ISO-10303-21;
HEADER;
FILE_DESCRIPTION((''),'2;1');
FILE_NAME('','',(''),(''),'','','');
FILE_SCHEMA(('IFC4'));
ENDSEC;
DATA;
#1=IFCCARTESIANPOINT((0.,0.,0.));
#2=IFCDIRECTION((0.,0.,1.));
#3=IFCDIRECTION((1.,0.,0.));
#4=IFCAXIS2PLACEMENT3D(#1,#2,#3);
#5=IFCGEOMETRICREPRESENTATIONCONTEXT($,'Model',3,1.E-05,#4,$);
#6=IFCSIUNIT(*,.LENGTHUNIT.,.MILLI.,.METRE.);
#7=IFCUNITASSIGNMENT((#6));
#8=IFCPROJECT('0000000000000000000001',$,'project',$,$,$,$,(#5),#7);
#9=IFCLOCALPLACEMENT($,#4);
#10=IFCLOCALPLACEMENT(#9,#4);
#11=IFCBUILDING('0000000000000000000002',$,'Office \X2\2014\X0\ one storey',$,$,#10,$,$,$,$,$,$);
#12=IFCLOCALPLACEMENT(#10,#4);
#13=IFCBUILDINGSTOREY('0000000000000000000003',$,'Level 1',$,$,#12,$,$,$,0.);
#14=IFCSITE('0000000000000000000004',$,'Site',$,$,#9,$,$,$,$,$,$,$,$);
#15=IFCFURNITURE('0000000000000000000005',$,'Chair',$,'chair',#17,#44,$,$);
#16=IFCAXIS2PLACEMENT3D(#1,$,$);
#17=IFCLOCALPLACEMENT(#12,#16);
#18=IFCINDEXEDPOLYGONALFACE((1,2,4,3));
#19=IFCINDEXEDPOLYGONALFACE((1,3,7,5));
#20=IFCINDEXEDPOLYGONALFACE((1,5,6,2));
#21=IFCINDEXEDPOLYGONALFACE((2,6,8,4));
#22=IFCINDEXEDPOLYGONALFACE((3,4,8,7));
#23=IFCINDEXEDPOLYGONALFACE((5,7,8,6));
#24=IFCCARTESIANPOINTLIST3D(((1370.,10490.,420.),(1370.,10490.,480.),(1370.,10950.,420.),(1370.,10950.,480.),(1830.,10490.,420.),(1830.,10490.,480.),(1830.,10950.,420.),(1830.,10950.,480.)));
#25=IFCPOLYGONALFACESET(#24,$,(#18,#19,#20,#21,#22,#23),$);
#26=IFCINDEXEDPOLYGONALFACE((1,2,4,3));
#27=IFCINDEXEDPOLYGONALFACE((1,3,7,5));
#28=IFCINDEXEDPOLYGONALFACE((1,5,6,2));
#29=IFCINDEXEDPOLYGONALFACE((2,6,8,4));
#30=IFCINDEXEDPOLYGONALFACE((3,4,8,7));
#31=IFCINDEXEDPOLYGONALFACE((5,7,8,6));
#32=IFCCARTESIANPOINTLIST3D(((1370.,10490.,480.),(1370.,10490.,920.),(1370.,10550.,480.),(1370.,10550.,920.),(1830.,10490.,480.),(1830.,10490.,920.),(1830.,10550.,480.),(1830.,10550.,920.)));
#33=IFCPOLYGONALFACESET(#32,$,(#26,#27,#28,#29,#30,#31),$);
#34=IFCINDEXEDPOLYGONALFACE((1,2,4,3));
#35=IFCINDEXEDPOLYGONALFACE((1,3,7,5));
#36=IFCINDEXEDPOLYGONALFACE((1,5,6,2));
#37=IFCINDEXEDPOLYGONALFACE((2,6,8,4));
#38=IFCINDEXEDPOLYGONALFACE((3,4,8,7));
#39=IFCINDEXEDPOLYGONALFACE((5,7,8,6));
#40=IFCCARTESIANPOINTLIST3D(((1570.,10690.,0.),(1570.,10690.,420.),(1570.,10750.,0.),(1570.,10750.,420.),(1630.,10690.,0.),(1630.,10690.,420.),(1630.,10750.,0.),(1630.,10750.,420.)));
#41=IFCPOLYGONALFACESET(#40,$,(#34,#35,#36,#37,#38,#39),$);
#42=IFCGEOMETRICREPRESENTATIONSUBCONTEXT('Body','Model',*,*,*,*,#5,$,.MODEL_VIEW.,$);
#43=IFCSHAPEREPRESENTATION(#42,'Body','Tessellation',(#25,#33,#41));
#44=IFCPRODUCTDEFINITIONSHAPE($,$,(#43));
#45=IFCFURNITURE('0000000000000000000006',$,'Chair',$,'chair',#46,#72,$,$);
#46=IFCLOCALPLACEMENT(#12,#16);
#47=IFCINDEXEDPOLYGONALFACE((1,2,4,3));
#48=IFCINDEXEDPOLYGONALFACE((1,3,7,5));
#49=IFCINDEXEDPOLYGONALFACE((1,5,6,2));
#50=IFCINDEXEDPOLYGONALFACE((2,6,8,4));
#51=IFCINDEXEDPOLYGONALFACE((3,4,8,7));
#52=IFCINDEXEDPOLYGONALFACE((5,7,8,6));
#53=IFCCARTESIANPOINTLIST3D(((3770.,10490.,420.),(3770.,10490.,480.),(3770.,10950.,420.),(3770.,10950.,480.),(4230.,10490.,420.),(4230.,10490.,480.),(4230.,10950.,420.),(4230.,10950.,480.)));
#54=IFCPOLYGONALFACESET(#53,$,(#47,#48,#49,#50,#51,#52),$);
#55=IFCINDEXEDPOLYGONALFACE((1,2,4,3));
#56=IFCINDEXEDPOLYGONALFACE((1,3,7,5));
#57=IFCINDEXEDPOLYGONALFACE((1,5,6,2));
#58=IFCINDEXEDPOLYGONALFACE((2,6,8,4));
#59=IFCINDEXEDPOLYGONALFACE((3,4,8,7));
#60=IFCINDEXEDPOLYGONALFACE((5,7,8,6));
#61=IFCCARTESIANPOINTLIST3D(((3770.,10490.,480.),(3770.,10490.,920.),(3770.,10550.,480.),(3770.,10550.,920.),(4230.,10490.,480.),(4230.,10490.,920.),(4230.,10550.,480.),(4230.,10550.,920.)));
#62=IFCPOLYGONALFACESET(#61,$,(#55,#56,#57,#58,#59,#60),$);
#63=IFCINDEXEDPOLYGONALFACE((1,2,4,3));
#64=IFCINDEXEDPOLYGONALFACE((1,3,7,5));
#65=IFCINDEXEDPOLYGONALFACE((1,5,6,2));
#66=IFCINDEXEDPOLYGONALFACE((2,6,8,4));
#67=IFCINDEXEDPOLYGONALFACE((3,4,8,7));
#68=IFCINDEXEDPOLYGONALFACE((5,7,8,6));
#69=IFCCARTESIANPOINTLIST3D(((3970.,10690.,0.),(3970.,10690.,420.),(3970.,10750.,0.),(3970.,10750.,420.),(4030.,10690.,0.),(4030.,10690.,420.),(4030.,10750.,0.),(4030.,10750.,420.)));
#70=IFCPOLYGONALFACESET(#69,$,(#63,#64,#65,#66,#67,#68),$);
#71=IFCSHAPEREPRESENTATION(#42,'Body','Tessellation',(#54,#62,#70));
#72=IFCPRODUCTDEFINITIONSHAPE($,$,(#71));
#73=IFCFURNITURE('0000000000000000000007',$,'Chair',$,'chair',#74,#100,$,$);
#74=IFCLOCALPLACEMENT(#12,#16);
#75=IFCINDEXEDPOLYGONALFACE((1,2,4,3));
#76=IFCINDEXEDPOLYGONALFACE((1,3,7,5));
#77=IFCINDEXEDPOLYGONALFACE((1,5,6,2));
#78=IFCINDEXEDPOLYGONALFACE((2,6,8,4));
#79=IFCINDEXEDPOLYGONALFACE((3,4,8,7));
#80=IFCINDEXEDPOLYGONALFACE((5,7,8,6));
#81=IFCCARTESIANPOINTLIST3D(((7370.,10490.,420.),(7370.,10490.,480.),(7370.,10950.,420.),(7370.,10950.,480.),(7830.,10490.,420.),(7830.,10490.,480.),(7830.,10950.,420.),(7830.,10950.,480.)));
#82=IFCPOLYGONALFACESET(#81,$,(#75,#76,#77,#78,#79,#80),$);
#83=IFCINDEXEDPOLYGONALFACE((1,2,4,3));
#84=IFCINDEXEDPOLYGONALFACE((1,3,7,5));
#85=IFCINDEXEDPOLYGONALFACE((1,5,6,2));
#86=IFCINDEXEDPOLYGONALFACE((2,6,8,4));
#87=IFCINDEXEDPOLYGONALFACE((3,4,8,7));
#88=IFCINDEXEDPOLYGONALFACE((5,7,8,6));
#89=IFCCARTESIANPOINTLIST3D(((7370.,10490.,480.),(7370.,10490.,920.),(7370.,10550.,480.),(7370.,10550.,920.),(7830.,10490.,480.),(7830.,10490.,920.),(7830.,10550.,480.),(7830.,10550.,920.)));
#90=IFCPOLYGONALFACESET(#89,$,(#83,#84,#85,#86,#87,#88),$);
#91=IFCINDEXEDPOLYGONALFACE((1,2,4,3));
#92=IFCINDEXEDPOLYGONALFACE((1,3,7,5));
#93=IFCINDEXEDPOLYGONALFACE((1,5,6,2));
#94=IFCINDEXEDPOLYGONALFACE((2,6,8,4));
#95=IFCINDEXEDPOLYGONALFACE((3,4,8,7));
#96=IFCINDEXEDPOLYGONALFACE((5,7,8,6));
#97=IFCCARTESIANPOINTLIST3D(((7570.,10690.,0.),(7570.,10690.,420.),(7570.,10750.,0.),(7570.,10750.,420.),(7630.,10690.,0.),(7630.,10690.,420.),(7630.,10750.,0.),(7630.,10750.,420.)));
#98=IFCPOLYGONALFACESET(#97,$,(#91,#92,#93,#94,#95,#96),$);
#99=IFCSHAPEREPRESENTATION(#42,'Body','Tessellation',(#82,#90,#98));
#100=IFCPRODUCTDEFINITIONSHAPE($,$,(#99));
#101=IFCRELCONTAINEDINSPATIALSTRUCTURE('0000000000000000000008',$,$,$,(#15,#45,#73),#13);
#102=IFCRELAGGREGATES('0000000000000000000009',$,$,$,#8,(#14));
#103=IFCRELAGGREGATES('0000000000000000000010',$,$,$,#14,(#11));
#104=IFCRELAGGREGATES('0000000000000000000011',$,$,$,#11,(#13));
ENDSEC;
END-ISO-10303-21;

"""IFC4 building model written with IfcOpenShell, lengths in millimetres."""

from ifc_helpers import new_model, si_unit, frame, frame_2d, origin, origin_with_axes, place, context, subcontext, project, spatial, rectangle, extrude, element, save


model = new_model("IFC4")

# Units and contexts
model_context = context("Model", 3, precision=1e-05, world=origin_with_axes())
body_context = subcontext(model_context, "Body", "Model", "MODEL_VIEW")
ifc_project = project(units=[si_unit("LENGTHUNIT", "METRE", prefix="MILLI")], contexts=[model_context])

# Site, building, storey
site_placement = place(None, origin_with_axes())
site = spatial("IfcSite", under=ifc_project, at=site_placement, Name="Site")
building_placement = place(site_placement, origin_with_axes())
building = spatial("IfcBuilding", under=site, at=building_placement, Name="Office — one storey")
storey_placement = place(building_placement, origin_with_axes())
storey = spatial("IfcBuildingStorey", under=building, at=storey_placement, Name="Level 1", Elevation=0.0)

# Furniture
for number, where, z_axis, x_axis, name in (
    (1, (1370.0, 10490.0, 0.0), (0.0, 0.0, 1.0), (1.0, 0.0, 0.0), "Chair"),
    (2, (3770.0, 10490.0, 0.0), (0.0, 0.0, 1.0), (1.0, 0.0, 0.0), "Chair"),
    (3, (7370.0, 10490.0, 0.0), (0.0, 0.0, 1.0), (1.0, 0.0, 0.0), "Chair"),
):
    element("IfcFurniture", number, at=place(storey_placement, frame(where, z_axis=z_axis, x_axis=x_axis)), inside=storey, Name=name, ObjectType="chair", context=body_context, shape_type="SweptSolid", body=[
        extrude(rectangle(XDim=460.0, YDim=460.0, at=frame_2d((230.0, 230.0))), frame((0.0, 0.0, 420.0)), (0.0, 0.0, 1.0), 60.0),
        extrude(rectangle(XDim=460.0, YDim=60.0, at=frame_2d((230.0, 30.0))), frame((0.0, 0.0, 480.0)), (0.0, 0.0, 1.0), 440.0),
        extrude(rectangle(XDim=60.0, YDim=60.0, at=frame_2d((230.0, 230.0))), origin(), (0.0, 0.0, 1.0), 420.0),
    ])

save(model, "model.ifc")
